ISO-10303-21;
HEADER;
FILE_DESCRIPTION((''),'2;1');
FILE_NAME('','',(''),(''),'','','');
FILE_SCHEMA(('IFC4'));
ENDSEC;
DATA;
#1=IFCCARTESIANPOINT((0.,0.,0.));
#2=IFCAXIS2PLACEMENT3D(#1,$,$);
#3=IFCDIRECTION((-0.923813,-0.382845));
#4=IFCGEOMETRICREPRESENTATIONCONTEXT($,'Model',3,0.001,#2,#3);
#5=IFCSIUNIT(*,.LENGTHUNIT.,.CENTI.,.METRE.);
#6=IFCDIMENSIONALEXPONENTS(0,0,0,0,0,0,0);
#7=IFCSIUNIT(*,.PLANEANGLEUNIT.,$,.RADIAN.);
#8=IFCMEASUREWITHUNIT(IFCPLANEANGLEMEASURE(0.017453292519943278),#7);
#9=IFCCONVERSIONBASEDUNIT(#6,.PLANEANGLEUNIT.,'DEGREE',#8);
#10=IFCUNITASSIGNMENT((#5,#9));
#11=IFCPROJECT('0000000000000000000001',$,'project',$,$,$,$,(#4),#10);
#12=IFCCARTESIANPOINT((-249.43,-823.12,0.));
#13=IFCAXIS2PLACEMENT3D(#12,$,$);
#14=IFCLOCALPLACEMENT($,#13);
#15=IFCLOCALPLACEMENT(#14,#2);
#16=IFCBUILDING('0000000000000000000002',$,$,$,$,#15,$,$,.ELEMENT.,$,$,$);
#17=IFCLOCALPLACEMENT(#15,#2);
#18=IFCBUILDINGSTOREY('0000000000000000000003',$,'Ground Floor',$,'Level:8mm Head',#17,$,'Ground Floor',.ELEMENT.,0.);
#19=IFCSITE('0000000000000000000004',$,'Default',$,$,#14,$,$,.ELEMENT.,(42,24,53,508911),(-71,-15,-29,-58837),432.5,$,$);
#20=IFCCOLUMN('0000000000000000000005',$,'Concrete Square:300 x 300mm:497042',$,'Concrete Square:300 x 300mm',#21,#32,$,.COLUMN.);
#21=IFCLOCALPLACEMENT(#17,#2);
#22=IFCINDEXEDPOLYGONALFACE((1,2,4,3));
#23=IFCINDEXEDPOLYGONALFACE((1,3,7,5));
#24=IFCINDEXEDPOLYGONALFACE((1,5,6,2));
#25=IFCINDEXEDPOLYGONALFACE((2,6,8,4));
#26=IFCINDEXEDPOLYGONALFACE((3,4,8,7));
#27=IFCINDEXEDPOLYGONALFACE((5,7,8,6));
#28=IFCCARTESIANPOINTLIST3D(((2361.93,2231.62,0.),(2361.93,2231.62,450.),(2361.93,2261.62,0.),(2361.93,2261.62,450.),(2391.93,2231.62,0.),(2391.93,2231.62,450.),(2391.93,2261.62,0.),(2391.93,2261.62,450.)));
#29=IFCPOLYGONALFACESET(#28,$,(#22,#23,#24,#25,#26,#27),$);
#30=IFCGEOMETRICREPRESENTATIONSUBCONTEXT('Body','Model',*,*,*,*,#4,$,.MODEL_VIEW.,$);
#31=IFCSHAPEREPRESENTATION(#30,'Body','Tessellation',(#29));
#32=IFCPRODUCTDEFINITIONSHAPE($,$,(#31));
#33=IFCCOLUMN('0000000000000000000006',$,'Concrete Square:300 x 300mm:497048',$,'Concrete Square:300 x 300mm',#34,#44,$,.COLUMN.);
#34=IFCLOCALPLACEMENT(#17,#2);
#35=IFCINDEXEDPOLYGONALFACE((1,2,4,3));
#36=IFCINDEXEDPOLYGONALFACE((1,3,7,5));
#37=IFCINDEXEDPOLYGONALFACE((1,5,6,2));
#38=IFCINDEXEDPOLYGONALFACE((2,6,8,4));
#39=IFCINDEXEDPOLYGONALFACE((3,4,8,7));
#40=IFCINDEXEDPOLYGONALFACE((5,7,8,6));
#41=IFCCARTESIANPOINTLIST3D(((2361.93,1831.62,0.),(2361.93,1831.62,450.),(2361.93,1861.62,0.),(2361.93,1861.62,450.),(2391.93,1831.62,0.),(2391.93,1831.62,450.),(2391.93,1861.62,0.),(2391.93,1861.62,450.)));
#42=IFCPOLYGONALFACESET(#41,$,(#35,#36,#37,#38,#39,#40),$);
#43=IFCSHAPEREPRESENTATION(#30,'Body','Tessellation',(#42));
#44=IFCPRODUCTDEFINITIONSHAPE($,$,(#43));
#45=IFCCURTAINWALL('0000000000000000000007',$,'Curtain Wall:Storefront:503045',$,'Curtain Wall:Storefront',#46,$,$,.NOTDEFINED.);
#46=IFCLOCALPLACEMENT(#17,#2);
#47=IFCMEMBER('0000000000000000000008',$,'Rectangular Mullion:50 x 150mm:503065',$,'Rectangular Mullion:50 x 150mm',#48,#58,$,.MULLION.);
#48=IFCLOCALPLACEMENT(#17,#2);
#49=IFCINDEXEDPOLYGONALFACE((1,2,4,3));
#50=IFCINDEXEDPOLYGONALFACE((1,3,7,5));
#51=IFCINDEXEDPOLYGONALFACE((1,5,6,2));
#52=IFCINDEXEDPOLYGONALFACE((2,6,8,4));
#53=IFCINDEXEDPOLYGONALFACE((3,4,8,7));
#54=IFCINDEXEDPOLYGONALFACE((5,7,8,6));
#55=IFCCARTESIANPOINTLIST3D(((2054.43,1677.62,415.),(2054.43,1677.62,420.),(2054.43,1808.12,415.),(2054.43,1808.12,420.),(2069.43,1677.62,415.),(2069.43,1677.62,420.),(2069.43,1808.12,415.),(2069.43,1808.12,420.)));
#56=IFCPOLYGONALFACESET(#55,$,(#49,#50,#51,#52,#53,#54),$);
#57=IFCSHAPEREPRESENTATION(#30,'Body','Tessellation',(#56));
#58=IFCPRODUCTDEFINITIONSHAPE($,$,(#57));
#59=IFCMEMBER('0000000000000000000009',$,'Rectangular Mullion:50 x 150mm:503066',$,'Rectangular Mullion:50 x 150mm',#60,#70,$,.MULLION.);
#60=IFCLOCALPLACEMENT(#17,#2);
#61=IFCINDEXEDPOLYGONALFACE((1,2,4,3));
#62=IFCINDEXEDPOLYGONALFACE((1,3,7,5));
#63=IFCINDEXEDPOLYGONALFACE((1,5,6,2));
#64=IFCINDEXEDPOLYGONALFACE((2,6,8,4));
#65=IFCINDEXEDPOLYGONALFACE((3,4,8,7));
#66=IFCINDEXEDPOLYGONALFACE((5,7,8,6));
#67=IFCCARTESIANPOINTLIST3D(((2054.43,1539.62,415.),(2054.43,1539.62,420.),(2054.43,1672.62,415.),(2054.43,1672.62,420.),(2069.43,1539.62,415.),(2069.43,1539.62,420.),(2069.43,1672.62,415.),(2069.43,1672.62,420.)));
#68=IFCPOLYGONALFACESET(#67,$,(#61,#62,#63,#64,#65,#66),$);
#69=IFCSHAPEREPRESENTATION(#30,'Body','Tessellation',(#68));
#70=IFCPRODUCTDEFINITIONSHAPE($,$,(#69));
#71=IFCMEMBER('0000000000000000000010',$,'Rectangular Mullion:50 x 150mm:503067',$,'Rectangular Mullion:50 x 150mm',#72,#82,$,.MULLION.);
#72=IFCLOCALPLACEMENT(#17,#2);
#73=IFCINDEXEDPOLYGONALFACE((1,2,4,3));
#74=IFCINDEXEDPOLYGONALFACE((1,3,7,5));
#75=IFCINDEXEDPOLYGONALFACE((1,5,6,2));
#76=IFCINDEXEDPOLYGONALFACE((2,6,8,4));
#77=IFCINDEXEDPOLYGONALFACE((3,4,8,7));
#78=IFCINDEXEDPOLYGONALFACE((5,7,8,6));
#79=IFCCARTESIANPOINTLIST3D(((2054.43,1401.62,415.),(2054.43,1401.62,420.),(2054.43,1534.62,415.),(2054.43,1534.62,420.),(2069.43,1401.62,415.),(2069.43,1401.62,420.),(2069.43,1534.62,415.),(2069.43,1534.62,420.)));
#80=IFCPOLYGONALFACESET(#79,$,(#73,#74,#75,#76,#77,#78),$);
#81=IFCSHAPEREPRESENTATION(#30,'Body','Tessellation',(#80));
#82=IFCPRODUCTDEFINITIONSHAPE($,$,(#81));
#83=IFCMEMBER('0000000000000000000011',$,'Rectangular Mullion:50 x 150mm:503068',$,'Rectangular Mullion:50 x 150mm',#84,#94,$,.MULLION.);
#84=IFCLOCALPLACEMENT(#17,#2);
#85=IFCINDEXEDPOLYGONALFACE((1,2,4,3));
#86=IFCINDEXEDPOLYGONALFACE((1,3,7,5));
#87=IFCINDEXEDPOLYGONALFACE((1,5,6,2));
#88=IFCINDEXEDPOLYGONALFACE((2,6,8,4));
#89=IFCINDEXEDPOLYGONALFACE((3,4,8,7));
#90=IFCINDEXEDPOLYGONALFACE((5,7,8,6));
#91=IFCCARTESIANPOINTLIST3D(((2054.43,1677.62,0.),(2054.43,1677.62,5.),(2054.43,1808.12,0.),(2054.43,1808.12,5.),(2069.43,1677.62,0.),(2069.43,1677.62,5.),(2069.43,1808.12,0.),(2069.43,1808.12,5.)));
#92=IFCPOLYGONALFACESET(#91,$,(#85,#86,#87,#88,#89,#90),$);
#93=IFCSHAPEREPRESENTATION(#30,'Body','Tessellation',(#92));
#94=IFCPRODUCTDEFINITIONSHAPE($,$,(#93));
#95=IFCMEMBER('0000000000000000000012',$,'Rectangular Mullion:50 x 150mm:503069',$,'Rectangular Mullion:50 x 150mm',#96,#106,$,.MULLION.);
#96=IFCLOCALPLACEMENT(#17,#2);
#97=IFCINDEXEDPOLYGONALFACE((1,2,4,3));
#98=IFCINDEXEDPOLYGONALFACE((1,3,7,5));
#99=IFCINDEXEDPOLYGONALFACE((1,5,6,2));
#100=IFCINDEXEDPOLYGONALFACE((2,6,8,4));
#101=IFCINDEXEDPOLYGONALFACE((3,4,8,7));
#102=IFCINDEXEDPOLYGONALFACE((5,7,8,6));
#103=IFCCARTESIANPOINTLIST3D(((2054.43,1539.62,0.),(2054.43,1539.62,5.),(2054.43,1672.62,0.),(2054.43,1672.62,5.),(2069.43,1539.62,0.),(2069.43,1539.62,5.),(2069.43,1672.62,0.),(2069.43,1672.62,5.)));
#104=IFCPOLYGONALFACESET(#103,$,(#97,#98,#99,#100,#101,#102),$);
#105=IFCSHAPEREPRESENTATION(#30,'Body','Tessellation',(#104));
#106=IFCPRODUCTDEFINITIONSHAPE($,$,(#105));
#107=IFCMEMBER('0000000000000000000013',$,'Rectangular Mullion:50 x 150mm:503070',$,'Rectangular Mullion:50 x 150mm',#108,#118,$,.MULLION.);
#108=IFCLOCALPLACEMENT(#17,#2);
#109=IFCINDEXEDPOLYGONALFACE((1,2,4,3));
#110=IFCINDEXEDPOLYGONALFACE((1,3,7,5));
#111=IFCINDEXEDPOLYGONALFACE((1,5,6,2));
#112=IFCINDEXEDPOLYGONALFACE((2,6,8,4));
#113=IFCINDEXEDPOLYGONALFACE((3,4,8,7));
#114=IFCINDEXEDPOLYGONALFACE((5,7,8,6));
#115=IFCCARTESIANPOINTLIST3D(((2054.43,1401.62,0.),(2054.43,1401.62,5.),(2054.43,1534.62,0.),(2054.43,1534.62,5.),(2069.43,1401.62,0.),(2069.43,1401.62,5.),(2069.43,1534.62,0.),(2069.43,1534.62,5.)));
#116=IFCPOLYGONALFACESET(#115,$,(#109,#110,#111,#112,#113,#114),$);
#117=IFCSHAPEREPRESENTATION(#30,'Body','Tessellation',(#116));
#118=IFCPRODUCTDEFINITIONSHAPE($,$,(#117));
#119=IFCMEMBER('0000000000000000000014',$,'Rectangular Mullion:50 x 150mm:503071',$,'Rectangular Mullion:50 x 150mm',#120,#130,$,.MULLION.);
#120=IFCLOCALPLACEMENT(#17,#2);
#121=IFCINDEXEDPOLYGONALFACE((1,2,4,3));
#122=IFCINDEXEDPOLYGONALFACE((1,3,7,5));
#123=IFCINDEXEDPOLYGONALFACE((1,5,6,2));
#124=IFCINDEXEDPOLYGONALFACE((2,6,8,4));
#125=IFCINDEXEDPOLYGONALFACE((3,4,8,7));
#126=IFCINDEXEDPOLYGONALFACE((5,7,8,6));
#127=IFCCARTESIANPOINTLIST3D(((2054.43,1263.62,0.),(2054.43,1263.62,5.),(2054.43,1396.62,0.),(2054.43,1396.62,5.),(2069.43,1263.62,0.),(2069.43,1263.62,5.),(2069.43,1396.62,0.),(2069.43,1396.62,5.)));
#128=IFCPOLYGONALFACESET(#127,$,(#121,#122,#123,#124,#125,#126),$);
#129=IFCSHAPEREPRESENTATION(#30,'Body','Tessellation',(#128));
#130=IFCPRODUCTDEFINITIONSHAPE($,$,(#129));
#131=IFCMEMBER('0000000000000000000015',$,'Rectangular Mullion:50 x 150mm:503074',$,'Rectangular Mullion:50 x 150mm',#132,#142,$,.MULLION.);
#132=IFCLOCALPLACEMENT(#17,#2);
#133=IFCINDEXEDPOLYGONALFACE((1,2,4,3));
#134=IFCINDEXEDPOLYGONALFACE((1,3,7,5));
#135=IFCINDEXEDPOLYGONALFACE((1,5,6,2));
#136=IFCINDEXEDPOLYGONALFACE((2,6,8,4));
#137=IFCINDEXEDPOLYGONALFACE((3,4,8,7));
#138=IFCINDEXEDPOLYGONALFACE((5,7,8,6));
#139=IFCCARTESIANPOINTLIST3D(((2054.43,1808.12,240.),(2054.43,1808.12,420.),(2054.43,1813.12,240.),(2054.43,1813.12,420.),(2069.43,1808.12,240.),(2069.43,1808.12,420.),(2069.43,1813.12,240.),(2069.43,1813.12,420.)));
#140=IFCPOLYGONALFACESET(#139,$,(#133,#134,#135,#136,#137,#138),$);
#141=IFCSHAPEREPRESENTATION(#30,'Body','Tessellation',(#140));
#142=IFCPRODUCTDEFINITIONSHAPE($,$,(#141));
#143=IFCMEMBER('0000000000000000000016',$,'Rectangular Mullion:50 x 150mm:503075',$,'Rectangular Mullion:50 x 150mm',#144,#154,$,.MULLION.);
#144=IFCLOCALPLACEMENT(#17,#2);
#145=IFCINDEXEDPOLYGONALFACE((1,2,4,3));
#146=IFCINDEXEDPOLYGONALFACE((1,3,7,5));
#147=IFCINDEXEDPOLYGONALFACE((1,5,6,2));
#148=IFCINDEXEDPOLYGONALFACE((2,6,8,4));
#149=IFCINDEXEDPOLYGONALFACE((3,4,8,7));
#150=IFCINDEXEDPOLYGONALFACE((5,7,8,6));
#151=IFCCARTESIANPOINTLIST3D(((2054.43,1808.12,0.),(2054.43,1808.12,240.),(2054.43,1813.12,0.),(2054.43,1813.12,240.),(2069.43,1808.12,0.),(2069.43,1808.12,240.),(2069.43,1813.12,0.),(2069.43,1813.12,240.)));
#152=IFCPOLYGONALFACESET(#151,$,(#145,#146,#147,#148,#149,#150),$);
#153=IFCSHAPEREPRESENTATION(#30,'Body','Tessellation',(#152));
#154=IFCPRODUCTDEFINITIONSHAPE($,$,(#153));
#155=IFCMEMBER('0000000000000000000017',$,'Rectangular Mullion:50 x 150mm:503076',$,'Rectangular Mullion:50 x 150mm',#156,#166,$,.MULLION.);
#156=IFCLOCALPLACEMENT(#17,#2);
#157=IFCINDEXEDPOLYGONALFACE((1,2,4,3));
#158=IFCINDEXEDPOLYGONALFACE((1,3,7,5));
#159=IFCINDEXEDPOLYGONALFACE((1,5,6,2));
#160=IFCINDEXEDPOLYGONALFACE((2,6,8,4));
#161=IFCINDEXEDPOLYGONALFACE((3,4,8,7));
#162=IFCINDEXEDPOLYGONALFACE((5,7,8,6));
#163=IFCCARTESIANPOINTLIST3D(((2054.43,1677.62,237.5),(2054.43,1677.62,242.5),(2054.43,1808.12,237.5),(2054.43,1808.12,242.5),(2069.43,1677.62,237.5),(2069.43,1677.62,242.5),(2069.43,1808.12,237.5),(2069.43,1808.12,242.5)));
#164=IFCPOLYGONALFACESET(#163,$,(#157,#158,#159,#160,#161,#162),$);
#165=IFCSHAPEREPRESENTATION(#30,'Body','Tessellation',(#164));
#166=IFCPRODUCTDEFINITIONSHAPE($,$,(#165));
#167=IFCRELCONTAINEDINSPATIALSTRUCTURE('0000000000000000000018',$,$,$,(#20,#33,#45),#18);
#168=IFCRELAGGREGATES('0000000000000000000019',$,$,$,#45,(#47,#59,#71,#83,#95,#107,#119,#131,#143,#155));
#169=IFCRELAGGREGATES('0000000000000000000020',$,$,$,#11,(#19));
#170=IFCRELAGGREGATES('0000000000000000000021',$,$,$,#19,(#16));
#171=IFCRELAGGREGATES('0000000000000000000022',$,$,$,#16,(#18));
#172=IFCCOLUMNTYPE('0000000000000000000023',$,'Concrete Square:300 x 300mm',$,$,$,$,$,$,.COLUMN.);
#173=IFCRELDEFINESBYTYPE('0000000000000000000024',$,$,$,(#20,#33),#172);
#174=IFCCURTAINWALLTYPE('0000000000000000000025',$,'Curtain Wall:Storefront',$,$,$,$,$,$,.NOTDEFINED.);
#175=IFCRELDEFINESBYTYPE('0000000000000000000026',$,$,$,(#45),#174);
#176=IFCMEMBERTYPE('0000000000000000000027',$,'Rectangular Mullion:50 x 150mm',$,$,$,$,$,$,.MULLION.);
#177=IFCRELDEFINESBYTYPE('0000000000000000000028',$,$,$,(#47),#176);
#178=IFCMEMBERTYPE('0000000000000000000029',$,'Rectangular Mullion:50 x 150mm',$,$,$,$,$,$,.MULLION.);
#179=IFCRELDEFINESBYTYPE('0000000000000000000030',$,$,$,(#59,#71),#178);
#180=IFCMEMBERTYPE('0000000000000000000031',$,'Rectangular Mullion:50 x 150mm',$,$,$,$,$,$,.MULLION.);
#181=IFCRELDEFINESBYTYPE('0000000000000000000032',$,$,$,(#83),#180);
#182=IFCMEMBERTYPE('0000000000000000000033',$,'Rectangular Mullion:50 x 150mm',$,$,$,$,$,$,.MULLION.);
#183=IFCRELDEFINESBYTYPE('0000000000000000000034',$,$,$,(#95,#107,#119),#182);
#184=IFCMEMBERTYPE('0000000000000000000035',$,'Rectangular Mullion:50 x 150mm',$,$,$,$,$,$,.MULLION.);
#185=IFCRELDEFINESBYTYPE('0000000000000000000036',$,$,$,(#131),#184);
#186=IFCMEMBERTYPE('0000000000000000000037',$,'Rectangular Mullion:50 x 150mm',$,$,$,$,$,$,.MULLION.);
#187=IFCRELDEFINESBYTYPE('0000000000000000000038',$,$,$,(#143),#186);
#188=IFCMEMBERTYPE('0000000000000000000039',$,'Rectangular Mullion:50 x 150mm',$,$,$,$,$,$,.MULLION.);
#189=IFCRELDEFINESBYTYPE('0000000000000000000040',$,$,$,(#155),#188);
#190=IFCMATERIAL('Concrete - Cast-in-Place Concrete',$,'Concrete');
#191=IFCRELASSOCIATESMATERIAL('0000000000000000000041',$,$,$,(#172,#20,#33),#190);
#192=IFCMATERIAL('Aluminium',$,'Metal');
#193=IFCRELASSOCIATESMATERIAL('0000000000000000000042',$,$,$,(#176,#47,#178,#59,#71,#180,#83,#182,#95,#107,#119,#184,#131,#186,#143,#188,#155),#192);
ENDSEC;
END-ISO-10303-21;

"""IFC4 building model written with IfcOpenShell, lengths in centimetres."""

from ifc_helpers import new_model, entity, si_unit, converted_unit, direction, frame, origin, place, context, subcontext, project, spatial, indexed_curve, outline, extrude, source, transform, mapped, material, type_object, type_shapes, element, aggregate, save


model = new_model("IFC4")

# Units and contexts
model_context = context("Model", 3, precision=0.001, world=origin(), true_north=direction((-0.923813, -0.382845)))
body_context = subcontext(model_context, "Body", "Model", "MODEL_VIEW")
ifc_project = project(units=[si_unit("LENGTHUNIT", "METRE", prefix="CENTI"), converted_unit("PLANEANGLEUNIT", "DEGREE", entity("IfcPlaneAngleMeasure", 0.017453292519943278), si_unit("PLANEANGLEUNIT", "RADIAN"), dimensions=[0, 0, 0, 0, 0, 0, 0])], contexts=[model_context])

# Site, building, storey
site_placement = place(None, frame((-249.43, -823.12, 0.0)))
site = spatial("IfcSite", under=ifc_project, at=site_placement, Name="Default", CompositionType="ELEMENT", RefLatitude=(42, 24, 53, 508911), RefLongitude=(-71, -15, -29, -58837), RefElevation=432.5)
building_placement = place(site_placement, origin())
building = spatial("IfcBuilding", under=site, at=building_placement, CompositionType="ELEMENT")
storey_placement = place(building_placement, origin())
storey = spatial("IfcBuildingStorey", under=building, at=storey_placement, Name="Ground Floor", ObjectType="Level:8mm Head", LongName="Ground Floor", CompositionType="ELEMENT", Elevation=0.0)

# Columns
ifc_material_1 = material(Name="Concrete - Cast-in-Place Concrete", Category="Concrete")
column_type = type_object("IfcColumnType", Name="Concrete Square:300 x 300mm", PredefinedType="COLUMN", material=ifc_material_1)
shared_shape_1 = source(origin(), body_context, "Body", "SweptSolid", [
    extrude(outline(indexed_curve([(-15.0, -15.0), (15.0, -15.0), (15.0, 15.0), (-15.0, 15.0), (-15.0, -15.0)], self_intersect=False)), frame((0.0, 0.0, 0.0), z_axis=(0.0, 0.0, 1.0), x_axis=(-1.0, 0.0, 0.0)), (0.0, 0.0, 1.0), 450.0),
])
type_shapes(column_type, [shared_shape_1])
for number, where, name in (
    (1, (2376.93, 2246.62, 0.0), "Concrete Square:300 x 300mm:497042"),
    (2, (2376.93, 1846.62, 0.0), "Concrete Square:300 x 300mm:497048"),
):
    element("IfcColumn", number, at=place(storey_placement, frame(where)), inside=storey, type_object=column_type, material=ifc_material_1, Name=name, ObjectType="Concrete Square:300 x 300mm", PredefinedType="COLUMN", context=body_context, shape_type="MappedRepresentation", body=[
        mapped(shared_shape_1, transform((0.0, 0.0, 0.0), scale=1.0)),
    ])

# Curtain wall, members
curtain_wall_type = type_object("IfcCurtainWallType", Name="Curtain Wall:Storefront", PredefinedType="NOTDEFINED")
curtain_wall_placement = place(storey_placement, origin())
curtain_wall = element("IfcCurtainWall", 3, at=curtain_wall_placement, inside=storey, type_object=curtain_wall_type, Name="Curtain Wall:Storefront:503045", ObjectType="Curtain Wall:Storefront", PredefinedType="NOTDEFINED")
ifc_material_2 = material(Name="Aluminium", Category="Metal")
member_type_1 = type_object("IfcMemberType", Name="Rectangular Mullion:50 x 150mm", PredefinedType="MULLION", material=ifc_material_2)
shared_shape_2 = source(origin(), body_context, "Body", "SweptSolid", [
    extrude(outline(indexed_curve([(-2.5, -7.5), (2.5, -7.5), (2.5, 7.5), (-2.5, 7.5), (-2.5, -7.5)], self_intersect=False)), frame((-2.5, 0.0, -130.5), z_axis=(0.0, 0.0, 1.0), x_axis=(-1.0, 0.0, 0.0)), (0.0, 0.0, 1.0), 130.5),
])
type_shapes(member_type_1, [shared_shape_2])
member_1_placement = place(curtain_wall_placement, frame((2061.93, 1677.62, 420.0), z_axis=(0.0, -1.0, 0.0), x_axis=(0.0, 0.0, 1.0)))
member_1 = element("IfcMember", 4, at=member_1_placement, type_object=member_type_1, material=ifc_material_2, Name="Rectangular Mullion:50 x 150mm:503065", ObjectType="Rectangular Mullion:50 x 150mm", PredefinedType="MULLION", context=body_context, shape_type="MappedRepresentation", body=[
    mapped(shared_shape_2, transform((0.0, 0.0, 0.0), scale=1.0)),
])
member_type_2 = type_object("IfcMemberType", Name="Rectangular Mullion:50 x 150mm", PredefinedType="MULLION", material=ifc_material_2)
shared_shape_3 = source(origin(), body_context, "Body", "SweptSolid", [
    extrude(outline(indexed_curve([(-2.5, -7.5), (2.5, -7.5), (2.5, 7.5), (-2.5, 7.5), (-2.5, -7.5)], self_intersect=False)), frame((-2.5, 0.0, -133.0), z_axis=(0.0, 0.0, 1.0), x_axis=(-1.0, 0.0, 0.0)), (0.0, 0.0, 1.0), 133.0),
])
type_shapes(member_type_2, [shared_shape_3])
member_2_placement = place(curtain_wall_placement, frame((2061.93, 1539.62, 420.0), z_axis=(0.0, -1.0, 0.0), x_axis=(0.0, 0.0, 1.0)))
member_2 = element("IfcMember", 5, at=member_2_placement, type_object=member_type_2, material=ifc_material_2, Name="Rectangular Mullion:50 x 150mm:503066", ObjectType="Rectangular Mullion:50 x 150mm", PredefinedType="MULLION", context=body_context, shape_type="MappedRepresentation", body=[
    mapped(shared_shape_3, transform((0.0, 0.0, 0.0), scale=1.0)),
])
member_3_placement = place(curtain_wall_placement, frame((2061.93, 1401.62, 420.0), z_axis=(0.0, -1.0, 0.0), x_axis=(0.0, 0.0, 1.0)))
member_3 = element("IfcMember", 6, at=member_3_placement, type_object=member_type_2, material=ifc_material_2, Name="Rectangular Mullion:50 x 150mm:503067", ObjectType="Rectangular Mullion:50 x 150mm", PredefinedType="MULLION", context=body_context, shape_type="MappedRepresentation", body=[
    mapped(shared_shape_3, transform((0.0, 0.0, 0.0), scale=1.0)),
])
member_type_3 = type_object("IfcMemberType", Name="Rectangular Mullion:50 x 150mm", PredefinedType="MULLION", material=ifc_material_2)
shared_shape_4 = source(origin(), body_context, "Body", "SweptSolid", [
    extrude(outline(indexed_curve([(-2.5, -7.5), (2.5, -7.5), (2.5, 7.5), (-2.5, 7.5), (-2.5, -7.5)], self_intersect=False)), frame((-2.5, 0.0, -130.5), z_axis=(0.0, 0.0, 1.0), x_axis=(-1.0, 0.0, 0.0)), (0.0, 0.0, 1.0), 130.5),
])
type_shapes(member_type_3, [shared_shape_4])
member_4_placement = place(curtain_wall_placement, frame((2061.93, 1808.12, 0.0), z_axis=(0.0, 1.0, 0.0), x_axis=(0.0, 0.0, -1.0)))
member_4 = element("IfcMember", 7, at=member_4_placement, type_object=member_type_3, material=ifc_material_2, Name="Rectangular Mullion:50 x 150mm:503068", ObjectType="Rectangular Mullion:50 x 150mm", PredefinedType="MULLION", context=body_context, shape_type="MappedRepresentation", body=[
    mapped(shared_shape_4, transform((0.0, 0.0, 0.0), scale=1.0)),
])
member_type_4 = type_object("IfcMemberType", Name="Rectangular Mullion:50 x 150mm", PredefinedType="MULLION", material=ifc_material_2)
shared_shape_5 = source(origin(), body_context, "Body", "SweptSolid", [
    extrude(outline(indexed_curve([(-2.5, -7.5), (2.5, -7.5), (2.5, 7.5), (-2.5, 7.5), (-2.5, -7.5)], self_intersect=False)), frame((-2.5, 0.0, -133.0), z_axis=(0.0, 0.0, 1.0), x_axis=(-1.0, 0.0, 0.0)), (0.0, 0.0, 1.0), 133.0),
])
type_shapes(member_type_4, [shared_shape_5])
member_5_placement = place(curtain_wall_placement, frame((2061.93, 1672.62, 0.0), z_axis=(0.0, 1.0, 0.0), x_axis=(0.0, 0.0, -1.0)))
member_5 = element("IfcMember", 8, at=member_5_placement, type_object=member_type_4, material=ifc_material_2, Name="Rectangular Mullion:50 x 150mm:503069", ObjectType="Rectangular Mullion:50 x 150mm", PredefinedType="MULLION", context=body_context, shape_type="MappedRepresentation", body=[
    mapped(shared_shape_5, transform((0.0, 0.0, 0.0), scale=1.0)),
])
member_6_placement = place(curtain_wall_placement, frame((2061.93, 1534.62, 0.0), z_axis=(0.0, 1.0, 0.0), x_axis=(0.0, 0.0, -1.0)))
member_6 = element("IfcMember", 9, at=member_6_placement, type_object=member_type_4, material=ifc_material_2, Name="Rectangular Mullion:50 x 150mm:503070", ObjectType="Rectangular Mullion:50 x 150mm", PredefinedType="MULLION", context=body_context, shape_type="MappedRepresentation", body=[
    mapped(shared_shape_5, transform((0.0, 0.0, 0.0), scale=1.0)),
])
member_7_placement = place(curtain_wall_placement, frame((2061.93, 1396.62, 0.0), z_axis=(0.0, 1.0, 0.0), x_axis=(0.0, 0.0, -1.0)))
member_7 = element("IfcMember", 10, at=member_7_placement, type_object=member_type_4, material=ifc_material_2, Name="Rectangular Mullion:50 x 150mm:503071", ObjectType="Rectangular Mullion:50 x 150mm", PredefinedType="MULLION", context=body_context, shape_type="MappedRepresentation", body=[
    mapped(shared_shape_5, transform((0.0, 0.0, 0.0), scale=1.0)),
])
member_type_5 = type_object("IfcMemberType", Name="Rectangular Mullion:50 x 150mm", PredefinedType="MULLION", material=ifc_material_2)
shared_shape_6 = source(origin(), body_context, "Body", "SweptSolid", [
    extrude(outline(indexed_curve([(-2.5, -7.5), (2.5, -7.5), (2.5, 7.5), (-2.5, 7.5), (-2.5, -7.5)], self_intersect=False)), frame((-2.5, 0.0, -180.0), z_axis=(0.0, 0.0, 1.0), x_axis=(-1.0, 0.0, 0.0)), (0.0, 0.0, 1.0), 180.0),
])
type_shapes(member_type_5, [shared_shape_6])
member_8_placement = place(curtain_wall_placement, frame((2061.93, 1813.12, 420.0), z_axis=(0.0, 0.0, 1.0), x_axis=(0.0, 1.0, 0.0)))
member_8 = element("IfcMember", 11, at=member_8_placement, type_object=member_type_5, material=ifc_material_2, Name="Rectangular Mullion:50 x 150mm:503074", ObjectType="Rectangular Mullion:50 x 150mm", PredefinedType="MULLION", context=body_context, shape_type="MappedRepresentation", body=[
    mapped(shared_shape_6, transform((0.0, 0.0, 0.0), scale=1.0)),
])
member_type_6 = type_object("IfcMemberType", Name="Rectangular Mullion:50 x 150mm", PredefinedType="MULLION", material=ifc_material_2)
shared_shape_7 = source(origin(), body_context, "Body", "SweptSolid", [
    extrude(outline(indexed_curve([(-2.5, -7.5), (2.5, -7.5), (2.5, 7.5), (-2.5, 7.5), (-2.5, -7.5)], self_intersect=False)), frame((-2.5, 0.0, -240.0), z_axis=(0.0, 0.0, 1.0), x_axis=(-1.0, 0.0, 0.0)), (0.0, 0.0, 1.0), 240.0),
])
type_shapes(member_type_6, [shared_shape_7])
member_9_placement = place(curtain_wall_placement, frame((2061.93, 1813.12, 240.0), z_axis=(0.0, 0.0, 1.0), x_axis=(0.0, 1.0, 0.0)))
member_9 = element("IfcMember", 12, at=member_9_placement, type_object=member_type_6, material=ifc_material_2, Name="Rectangular Mullion:50 x 150mm:503075", ObjectType="Rectangular Mullion:50 x 150mm", PredefinedType="MULLION", context=body_context, shape_type="MappedRepresentation", body=[
    mapped(shared_shape_7, transform((0.0, 0.0, 0.0), scale=1.0)),
])
member_type_7 = type_object("IfcMemberType", Name="Rectangular Mullion:50 x 150mm", PredefinedType="MULLION", material=ifc_material_2)
shared_shape_8 = source(origin(), body_context, "Body", "SweptSolid", [
    extrude(outline(indexed_curve([(-2.5, -7.5), (2.5, -7.5), (2.5, 7.5), (-2.5, 7.5), (-2.5, -7.5)], self_intersect=False)), frame((0.0, 0.0, -130.5), z_axis=(0.0, 0.0, 1.0), x_axis=(-1.0, 0.0, 0.0)), (0.0, 0.0, 1.0), 130.5),
])
type_shapes(member_type_7, [shared_shape_8])
member_10_placement = place(curtain_wall_placement, frame((2061.93, 1677.62, 240.0), z_axis=(0.0, -1.0, 0.0), x_axis=(0.0, 0.0, 1.0)))
member_10 = element("IfcMember", 13, at=member_10_placement, type_object=member_type_7, material=ifc_material_2, Name="Rectangular Mullion:50 x 150mm:503076", ObjectType="Rectangular Mullion:50 x 150mm", PredefinedType="MULLION", context=body_context, shape_type="MappedRepresentation", body=[
    mapped(shared_shape_8, transform((0.0, 0.0, 0.0), scale=1.0)),
])
aggregate(curtain_wall, [member_1, member_2, member_3, member_4, member_5, member_6, member_7, member_8, member_9, member_10])

save(model, "model.ifc")
